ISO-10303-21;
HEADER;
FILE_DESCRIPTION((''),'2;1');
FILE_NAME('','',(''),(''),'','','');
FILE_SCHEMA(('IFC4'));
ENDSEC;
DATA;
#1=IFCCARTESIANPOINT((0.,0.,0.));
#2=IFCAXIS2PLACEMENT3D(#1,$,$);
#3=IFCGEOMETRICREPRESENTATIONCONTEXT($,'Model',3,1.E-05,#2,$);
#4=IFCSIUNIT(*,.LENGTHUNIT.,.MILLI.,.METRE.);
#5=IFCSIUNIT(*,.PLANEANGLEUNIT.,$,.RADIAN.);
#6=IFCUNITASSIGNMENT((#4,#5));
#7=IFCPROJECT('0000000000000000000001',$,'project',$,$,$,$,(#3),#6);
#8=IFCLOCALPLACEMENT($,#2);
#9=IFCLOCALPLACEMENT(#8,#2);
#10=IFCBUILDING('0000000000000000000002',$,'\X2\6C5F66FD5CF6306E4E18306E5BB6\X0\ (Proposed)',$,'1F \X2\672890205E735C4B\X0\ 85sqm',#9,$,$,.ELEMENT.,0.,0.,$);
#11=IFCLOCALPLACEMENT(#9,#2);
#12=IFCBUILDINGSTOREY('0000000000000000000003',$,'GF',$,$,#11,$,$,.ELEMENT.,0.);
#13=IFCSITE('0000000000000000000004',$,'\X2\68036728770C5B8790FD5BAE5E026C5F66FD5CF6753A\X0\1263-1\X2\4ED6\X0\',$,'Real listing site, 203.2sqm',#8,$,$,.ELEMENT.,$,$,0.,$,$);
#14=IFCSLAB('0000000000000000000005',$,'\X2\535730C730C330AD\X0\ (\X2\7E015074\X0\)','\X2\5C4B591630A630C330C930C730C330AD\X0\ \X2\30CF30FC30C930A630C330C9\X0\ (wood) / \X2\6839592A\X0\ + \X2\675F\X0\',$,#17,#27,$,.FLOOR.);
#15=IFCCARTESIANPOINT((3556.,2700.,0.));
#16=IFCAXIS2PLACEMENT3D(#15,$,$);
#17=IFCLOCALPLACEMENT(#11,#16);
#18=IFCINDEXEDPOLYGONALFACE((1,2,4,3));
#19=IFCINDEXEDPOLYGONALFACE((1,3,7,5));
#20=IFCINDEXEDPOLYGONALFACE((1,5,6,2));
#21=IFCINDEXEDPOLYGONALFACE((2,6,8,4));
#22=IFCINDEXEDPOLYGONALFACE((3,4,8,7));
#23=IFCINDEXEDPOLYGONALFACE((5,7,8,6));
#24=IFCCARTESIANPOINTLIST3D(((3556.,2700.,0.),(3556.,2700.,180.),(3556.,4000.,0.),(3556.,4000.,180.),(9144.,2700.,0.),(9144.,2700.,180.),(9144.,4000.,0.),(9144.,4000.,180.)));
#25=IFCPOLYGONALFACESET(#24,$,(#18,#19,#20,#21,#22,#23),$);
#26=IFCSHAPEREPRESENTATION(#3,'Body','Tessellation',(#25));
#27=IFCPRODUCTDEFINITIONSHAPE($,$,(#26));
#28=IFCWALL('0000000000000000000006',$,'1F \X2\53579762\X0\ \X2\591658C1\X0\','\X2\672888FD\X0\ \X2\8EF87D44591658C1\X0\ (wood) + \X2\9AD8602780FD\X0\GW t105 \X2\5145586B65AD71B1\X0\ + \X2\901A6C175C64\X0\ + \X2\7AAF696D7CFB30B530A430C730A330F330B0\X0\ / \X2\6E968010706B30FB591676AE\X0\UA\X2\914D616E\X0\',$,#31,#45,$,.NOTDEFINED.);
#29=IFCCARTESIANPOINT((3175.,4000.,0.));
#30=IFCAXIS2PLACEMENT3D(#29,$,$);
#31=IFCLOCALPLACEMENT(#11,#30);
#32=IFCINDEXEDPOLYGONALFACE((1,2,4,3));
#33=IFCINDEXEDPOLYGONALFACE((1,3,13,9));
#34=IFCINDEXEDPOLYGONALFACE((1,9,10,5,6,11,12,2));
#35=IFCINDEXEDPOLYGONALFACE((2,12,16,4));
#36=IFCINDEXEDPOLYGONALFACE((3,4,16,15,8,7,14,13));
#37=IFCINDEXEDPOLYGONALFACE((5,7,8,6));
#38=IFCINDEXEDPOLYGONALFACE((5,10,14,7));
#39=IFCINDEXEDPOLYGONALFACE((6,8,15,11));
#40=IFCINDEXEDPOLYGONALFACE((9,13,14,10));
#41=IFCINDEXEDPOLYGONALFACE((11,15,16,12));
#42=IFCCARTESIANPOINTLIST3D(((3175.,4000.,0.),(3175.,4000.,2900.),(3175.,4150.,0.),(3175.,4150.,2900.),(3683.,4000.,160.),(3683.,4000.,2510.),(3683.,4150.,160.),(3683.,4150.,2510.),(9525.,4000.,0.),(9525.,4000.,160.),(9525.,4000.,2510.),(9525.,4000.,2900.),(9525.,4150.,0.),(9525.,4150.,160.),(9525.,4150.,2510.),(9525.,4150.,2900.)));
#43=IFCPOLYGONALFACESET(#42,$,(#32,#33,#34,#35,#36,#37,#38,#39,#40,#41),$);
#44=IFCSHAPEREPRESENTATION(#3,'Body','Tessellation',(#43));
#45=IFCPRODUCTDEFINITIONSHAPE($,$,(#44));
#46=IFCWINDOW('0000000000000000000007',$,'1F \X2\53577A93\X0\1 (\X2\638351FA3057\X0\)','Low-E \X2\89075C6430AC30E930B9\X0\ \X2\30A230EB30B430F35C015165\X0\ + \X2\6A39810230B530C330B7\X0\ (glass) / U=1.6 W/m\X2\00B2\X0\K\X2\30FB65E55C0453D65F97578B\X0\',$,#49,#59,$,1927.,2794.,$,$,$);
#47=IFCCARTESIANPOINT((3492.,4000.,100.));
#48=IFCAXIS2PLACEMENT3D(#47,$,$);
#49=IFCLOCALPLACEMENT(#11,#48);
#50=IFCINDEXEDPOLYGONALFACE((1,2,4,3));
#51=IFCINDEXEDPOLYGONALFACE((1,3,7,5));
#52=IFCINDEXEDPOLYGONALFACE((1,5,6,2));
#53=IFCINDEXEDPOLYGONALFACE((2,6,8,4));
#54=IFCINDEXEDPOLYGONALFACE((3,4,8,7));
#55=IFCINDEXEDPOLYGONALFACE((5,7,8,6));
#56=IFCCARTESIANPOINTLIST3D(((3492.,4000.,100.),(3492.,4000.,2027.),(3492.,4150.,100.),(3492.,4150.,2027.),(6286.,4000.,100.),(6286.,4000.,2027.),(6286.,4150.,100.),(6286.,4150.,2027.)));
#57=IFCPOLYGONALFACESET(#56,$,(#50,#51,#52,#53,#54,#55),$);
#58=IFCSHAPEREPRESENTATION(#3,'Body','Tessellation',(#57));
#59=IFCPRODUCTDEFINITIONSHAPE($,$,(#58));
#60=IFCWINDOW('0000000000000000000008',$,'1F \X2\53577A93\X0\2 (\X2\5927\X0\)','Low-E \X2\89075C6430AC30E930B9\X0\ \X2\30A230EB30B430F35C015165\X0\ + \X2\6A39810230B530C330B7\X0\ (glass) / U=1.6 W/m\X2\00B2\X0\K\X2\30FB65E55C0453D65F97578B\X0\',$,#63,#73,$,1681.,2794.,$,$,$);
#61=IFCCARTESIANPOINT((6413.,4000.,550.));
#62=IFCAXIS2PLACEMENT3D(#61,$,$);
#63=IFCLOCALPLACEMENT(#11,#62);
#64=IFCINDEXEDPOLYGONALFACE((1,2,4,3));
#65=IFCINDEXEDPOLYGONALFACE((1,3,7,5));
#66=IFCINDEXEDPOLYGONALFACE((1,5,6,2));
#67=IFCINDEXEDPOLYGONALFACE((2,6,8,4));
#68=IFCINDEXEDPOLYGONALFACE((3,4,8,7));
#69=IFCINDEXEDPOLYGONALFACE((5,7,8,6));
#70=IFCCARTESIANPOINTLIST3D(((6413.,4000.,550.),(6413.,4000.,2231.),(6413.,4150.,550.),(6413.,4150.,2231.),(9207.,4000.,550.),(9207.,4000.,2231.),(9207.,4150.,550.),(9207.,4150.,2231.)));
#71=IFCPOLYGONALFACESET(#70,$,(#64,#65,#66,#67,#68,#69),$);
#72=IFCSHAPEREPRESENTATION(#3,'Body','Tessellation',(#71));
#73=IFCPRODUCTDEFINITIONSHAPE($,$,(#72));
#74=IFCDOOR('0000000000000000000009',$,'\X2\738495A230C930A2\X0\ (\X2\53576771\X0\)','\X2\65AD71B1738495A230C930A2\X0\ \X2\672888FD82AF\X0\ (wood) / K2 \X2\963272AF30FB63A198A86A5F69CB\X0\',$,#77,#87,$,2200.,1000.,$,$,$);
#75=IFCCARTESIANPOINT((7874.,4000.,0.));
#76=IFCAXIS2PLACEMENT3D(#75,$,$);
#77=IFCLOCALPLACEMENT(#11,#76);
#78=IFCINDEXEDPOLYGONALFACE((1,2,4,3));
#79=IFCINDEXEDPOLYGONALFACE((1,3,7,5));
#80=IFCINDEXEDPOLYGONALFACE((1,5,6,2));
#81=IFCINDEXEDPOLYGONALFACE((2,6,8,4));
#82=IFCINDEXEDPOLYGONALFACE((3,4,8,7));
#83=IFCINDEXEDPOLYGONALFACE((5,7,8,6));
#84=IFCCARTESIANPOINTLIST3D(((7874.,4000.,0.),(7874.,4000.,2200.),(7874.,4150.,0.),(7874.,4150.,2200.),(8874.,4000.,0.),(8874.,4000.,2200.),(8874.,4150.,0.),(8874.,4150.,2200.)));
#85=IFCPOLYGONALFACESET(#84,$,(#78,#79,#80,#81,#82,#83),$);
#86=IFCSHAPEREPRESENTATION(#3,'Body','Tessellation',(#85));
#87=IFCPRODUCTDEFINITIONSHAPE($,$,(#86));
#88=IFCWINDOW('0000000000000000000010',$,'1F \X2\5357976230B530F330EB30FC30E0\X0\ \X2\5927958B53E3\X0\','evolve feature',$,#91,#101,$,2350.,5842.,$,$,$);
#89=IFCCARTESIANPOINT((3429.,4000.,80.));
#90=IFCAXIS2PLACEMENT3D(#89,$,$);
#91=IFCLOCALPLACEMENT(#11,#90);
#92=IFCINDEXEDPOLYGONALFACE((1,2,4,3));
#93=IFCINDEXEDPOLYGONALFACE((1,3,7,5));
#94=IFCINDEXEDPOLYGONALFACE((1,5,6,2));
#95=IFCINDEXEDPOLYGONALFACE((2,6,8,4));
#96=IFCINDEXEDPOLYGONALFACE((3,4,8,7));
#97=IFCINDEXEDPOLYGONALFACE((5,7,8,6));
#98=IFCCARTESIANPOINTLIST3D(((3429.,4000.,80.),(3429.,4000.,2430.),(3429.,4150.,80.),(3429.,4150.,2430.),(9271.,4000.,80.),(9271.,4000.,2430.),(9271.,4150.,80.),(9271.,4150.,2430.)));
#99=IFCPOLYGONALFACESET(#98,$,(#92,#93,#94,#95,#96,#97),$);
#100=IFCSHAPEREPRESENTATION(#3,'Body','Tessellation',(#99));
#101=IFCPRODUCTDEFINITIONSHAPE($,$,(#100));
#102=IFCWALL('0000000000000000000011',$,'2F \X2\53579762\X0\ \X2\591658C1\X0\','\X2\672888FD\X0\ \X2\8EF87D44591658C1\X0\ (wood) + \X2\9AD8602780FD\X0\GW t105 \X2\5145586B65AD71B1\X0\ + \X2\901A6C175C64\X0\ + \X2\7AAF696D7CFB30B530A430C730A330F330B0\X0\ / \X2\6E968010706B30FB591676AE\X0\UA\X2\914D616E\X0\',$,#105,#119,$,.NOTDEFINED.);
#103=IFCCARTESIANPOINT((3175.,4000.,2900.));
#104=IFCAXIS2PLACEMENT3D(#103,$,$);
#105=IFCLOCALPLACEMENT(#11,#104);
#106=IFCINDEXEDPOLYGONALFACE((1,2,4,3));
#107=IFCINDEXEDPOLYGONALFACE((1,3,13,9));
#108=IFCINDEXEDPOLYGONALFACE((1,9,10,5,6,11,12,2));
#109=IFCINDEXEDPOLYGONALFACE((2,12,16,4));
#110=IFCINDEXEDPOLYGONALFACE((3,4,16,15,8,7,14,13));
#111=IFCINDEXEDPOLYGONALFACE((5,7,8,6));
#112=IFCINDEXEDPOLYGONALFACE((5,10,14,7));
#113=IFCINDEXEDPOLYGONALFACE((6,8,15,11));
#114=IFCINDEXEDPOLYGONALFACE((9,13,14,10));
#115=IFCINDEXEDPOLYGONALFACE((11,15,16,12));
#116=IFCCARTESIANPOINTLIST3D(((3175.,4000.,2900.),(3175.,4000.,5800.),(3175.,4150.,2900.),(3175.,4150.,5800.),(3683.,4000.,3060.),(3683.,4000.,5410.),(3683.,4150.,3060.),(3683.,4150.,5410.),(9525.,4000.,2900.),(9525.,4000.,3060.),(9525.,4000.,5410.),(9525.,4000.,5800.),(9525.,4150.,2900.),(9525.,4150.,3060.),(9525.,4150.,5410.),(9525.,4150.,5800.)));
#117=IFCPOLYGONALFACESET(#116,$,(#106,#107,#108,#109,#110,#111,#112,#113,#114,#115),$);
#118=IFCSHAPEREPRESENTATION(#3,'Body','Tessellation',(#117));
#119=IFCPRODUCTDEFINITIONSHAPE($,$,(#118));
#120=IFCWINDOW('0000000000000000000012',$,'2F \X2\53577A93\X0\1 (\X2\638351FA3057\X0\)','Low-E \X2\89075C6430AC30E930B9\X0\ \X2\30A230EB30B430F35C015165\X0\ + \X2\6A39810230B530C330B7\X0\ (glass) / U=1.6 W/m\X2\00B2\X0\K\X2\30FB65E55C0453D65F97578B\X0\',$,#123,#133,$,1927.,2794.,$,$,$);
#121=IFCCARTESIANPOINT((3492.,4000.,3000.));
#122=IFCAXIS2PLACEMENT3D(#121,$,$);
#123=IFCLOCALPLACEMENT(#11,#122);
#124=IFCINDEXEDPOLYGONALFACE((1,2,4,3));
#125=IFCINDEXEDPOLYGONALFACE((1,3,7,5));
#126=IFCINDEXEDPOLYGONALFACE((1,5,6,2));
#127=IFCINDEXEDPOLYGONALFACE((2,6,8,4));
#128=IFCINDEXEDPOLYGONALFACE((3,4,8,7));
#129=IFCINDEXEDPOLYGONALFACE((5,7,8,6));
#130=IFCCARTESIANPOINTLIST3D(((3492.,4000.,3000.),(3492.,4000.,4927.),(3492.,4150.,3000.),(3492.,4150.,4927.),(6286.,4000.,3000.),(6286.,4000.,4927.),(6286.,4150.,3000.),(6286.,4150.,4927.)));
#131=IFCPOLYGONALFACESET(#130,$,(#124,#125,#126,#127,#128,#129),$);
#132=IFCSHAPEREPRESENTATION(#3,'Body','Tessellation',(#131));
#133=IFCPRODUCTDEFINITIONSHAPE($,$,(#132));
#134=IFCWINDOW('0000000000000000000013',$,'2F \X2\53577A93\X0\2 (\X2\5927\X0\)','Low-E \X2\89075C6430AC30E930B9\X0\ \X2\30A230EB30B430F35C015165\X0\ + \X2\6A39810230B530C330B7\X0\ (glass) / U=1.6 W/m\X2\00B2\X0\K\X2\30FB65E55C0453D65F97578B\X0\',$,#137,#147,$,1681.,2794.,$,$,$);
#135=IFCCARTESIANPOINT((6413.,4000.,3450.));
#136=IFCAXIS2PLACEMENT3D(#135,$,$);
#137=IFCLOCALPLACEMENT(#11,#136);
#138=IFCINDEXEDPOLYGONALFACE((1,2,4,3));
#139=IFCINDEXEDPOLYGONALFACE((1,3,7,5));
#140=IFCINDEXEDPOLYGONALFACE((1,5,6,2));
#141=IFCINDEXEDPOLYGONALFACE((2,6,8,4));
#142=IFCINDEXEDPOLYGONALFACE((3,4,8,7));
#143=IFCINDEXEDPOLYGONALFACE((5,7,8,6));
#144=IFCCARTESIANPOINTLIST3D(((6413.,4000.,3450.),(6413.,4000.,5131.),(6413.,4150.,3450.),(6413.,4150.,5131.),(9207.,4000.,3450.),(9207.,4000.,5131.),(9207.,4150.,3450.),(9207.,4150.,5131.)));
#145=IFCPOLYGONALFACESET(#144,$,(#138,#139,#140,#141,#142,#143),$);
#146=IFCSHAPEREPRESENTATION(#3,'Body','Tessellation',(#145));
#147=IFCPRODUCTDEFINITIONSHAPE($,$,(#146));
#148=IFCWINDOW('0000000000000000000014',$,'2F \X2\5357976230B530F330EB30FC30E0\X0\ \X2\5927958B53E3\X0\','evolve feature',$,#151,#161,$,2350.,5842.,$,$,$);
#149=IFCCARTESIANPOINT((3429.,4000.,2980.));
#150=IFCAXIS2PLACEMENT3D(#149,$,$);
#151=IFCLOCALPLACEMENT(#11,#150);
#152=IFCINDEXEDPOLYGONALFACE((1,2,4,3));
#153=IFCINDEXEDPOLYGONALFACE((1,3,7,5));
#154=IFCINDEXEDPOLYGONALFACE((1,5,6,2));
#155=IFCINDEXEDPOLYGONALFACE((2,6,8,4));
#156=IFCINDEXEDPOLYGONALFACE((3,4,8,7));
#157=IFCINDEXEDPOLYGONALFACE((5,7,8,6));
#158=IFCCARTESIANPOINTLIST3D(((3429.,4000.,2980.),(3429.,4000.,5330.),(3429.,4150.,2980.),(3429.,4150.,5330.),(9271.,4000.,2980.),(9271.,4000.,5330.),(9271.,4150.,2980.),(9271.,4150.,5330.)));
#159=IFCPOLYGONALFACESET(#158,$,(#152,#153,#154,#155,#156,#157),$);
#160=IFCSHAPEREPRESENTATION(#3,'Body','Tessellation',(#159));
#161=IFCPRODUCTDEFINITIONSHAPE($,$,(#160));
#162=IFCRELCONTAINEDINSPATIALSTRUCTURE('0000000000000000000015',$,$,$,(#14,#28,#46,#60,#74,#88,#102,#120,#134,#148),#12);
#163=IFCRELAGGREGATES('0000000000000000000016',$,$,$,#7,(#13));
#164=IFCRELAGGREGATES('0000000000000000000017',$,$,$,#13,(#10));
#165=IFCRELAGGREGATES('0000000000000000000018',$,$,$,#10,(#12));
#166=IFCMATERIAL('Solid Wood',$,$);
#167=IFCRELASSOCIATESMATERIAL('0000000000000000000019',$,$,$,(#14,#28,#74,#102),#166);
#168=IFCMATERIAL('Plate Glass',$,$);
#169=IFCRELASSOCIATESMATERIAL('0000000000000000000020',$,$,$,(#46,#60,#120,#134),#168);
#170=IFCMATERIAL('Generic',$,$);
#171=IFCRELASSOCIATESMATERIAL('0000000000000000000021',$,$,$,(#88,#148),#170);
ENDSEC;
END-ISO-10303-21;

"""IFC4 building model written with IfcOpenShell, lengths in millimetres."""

from ifc_helpers import new_model, si_unit, frame, frame_2d, origin, place, context, project, spatial, rectangle, extrude, material, element, fill, save


model = new_model("IFC4")

# Units and contexts
model_context = context("Model", 3, precision=1e-05, world=origin())
ifc_project = project(units=[si_unit("LENGTHUNIT", "METRE", prefix="MILLI"), si_unit("PLANEANGLEUNIT", "RADIAN")], contexts=[model_context])

# Site, building, storey
site_placement = place(None, origin())
site = spatial("IfcSite", under=ifc_project, at=site_placement, Name="栃木県宇都宮市江曽島町1263-1他", ObjectType="Real listing site, 203.2sqm", CompositionType="ELEMENT", RefElevation=0.0)
building_placement = place(site_placement, origin())
building = spatial("IfcBuilding", under=site, at=building_placement, Name="江曽島の丘の家 (Proposed)", ObjectType="1F 木造平屋 85sqm", CompositionType="ELEMENT", ElevationOfRefHeight=0.0, ElevationOfTerrain=0.0)
storey_placement = place(building_placement, origin())
storey = spatial("IfcBuildingStorey", under=building, at=storey_placement, Name="GF", CompositionType="ELEMENT", Elevation=0.0)

# Slab
ifc_material_1 = material(Name="Solid Wood")
slab_1_placement = place(storey_placement, frame((3556.0, 2700.0, 0.0)))
element("IfcSlab", 1, at=slab_1_placement, inside=storey, material=ifc_material_1, Name="南デッキ (縁側)", Description="屋外ウッドデッキ ハードウッド (wood) / 根太 + 束", PredefinedType="FLOOR", context=model_context, shape_type="SweptSolid", body=[
    extrude(rectangle(XDim=5588.0, YDim=1300.0, at=frame_2d((2794.0, 650.0))), frame((3556.0, 2700.0, 0.0)), (0.0, 0.0, 1.0), 180.0),
])
ifc_material_2 = material(Name="Generic")

# Wall, openings, windows, door
wall_1_placement = place(storey_placement, frame((3175.0, 4000.0, 0.0)))
wall_1 = element("IfcWall", 2, at=wall_1_placement, inside=storey, material=ifc_material_1, Name="1F 南面 外壁", Description="木製 軸組外壁 (wood) + 高性能GW t105 充填断熱 + 通気層 + 窯業系サイディング / 準耐火・外皮UA配慮", PredefinedType="NOTDEFINED", context=model_context, shape_type="SweptSolid", body=[
    extrude(rectangle(XDim=6350.0, YDim=150.0, at=frame_2d((3175.0, 75.0))), frame((3175.0, 4000.0, 0.0)), (0.0, 0.0, 1.0), 2900.0),
])
opening_1_placement = place(storey_placement, frame((3492.0, 4000.0, 100.0)))
opening_1 = element("IfcOpeningElement", 3, at=opening_1_placement, cuts=wall_1, PredefinedType="NOTDEFINED", context=model_context, shape_type="SweptSolid", body=[
    extrude(rectangle(XDim=2794.0, YDim=150.0, at=frame_2d((1397.0, 75.0))), frame((3492.0, 4000.0, 100.0)), (0.0, 0.0, 1.0), 1927.0),
])
opening_2_placement = place(storey_placement, frame((6413.0, 4000.0, 550.0)))
opening_2 = element("IfcOpeningElement", 4, at=opening_2_placement, cuts=wall_1, PredefinedType="NOTDEFINED", context=model_context, shape_type="SweptSolid", body=[
    extrude(rectangle(XDim=2794.0, YDim=150.0, at=frame_2d((1397.0, 75.0))), frame((6413.0, 4000.0, 550.0)), (0.0, 0.0, 1.0), 1681.0),
])
opening_3_placement = place(storey_placement, frame((7874.0, 4000.0, 0.0)))
opening_3 = element("IfcOpeningElement", 5, at=opening_3_placement, cuts=wall_1, PredefinedType="NOTDEFINED", context=model_context, shape_type="SweptSolid", body=[
    extrude(rectangle(XDim=1000.0, YDim=150.0, at=frame_2d((500.0, 75.0))), frame((7874.0, 4000.0, 0.0)), (0.0, 0.0, 1.0), 2200.0),
])
opening_4_placement = place(storey_placement, frame((3429.0, 4000.0, 80.0)))
opening_4 = element("IfcOpeningElement", 6, at=opening_4_placement, cuts=wall_1, PredefinedType="NOTDEFINED", context=model_context, shape_type="SweptSolid", body=[
    extrude(rectangle(XDim=5842.0, YDim=150.0, at=frame_2d((2921.0, 75.0))), frame((3429.0, 4000.0, 80.0)), (0.0, 0.0, 1.0), 2350.0),
])
ifc_material_3 = material(Name="Plate Glass")
window_1_placement = place(storey_placement, frame((3492.0, 4000.0, 100.0)))
window_1 = element("IfcWindow", 7, at=window_1_placement, inside=storey, material=ifc_material_3, Name="1F 南窓1 (掃出し)", Description="Low-E 複層ガラス アルゴン封入 + 樹脂サッシ (glass) / U=1.6 W/m²K・日射取得型", OverallHeight=1927.0, OverallWidth=2794.0, context=model_context, shape_type="SweptSolid", body=[
    extrude(rectangle(XDim=2794.0, YDim=150.0, at=frame_2d((1397.0, 75.0))), frame((3492.0, 4000.0, 100.0)), (0.0, 0.0, 1.0), 1927.0),
])
fill(opening_1, window_1)
window_2_placement = place(storey_placement, frame((6413.0, 4000.0, 550.0)))
window_2 = element("IfcWindow", 8, at=window_2_placement, inside=storey, material=ifc_material_3, Name="1F 南窓2 (大)", Description="Low-E 複層ガラス アルゴン封入 + 樹脂サッシ (glass) / U=1.6 W/m²K・日射取得型", OverallHeight=1681.0, OverallWidth=2794.0, context=model_context, shape_type="SweptSolid", body=[
    extrude(rectangle(XDim=2794.0, YDim=150.0, at=frame_2d((1397.0, 75.0))), frame((6413.0, 4000.0, 550.0)), (0.0, 0.0, 1.0), 1681.0),
])
fill(opening_2, window_2)
door_placement = place(storey_placement, frame((7874.0, 4000.0, 0.0)))
door = element("IfcDoor", 9, at=door_placement, inside=storey, material=ifc_material_1, Name="玄関ドア (南東)", Description="断熱玄関ドア 木製芯 (wood) / K2 防犯・採風機構", OverallHeight=2200.0, OverallWidth=1000.0, context=model_context, shape_type="SweptSolid", body=[
    extrude(rectangle(XDim=1000.0, YDim=150.0, at=frame_2d((500.0, 75.0))), frame((7874.0, 4000.0, 0.0)), (0.0, 0.0, 1.0), 2200.0),
])
fill(opening_3, door)
window_3_placement = place(storey_placement, frame((3429.0, 4000.0, 80.0)))
window_3 = element("IfcWindow", 10, at=window_3_placement, inside=storey, material=ifc_material_2, Name="1F 南面サンルーム 大開口", Description="evolve feature", OverallHeight=2350.0, OverallWidth=5842.0, context=model_context, shape_type="SweptSolid", body=[
    extrude(rectangle(XDim=5842.0, YDim=150.0, at=frame_2d((2921.0, 75.0))), frame((3429.0, 4000.0, 80.0)), (0.0, 0.0, 1.0), 2350.0),
])
fill(opening_4, window_3)

# Wall, openings, windows
wall_2_placement = place(storey_placement, frame((3175.0, 4000.0, 2900.0)))
wall_2 = element("IfcWall", 11, at=wall_2_placement, inside=storey, material=ifc_material_1, Name="2F 南面 外壁", Description="木製 軸組外壁 (wood) + 高性能GW t105 充填断熱 + 通気層 + 窯業系サイディング / 準耐火・外皮UA配慮", PredefinedType="NOTDEFINED", context=model_context, shape_type="SweptSolid", body=[
    extrude(rectangle(XDim=6350.0, YDim=150.0, at=frame_2d((3175.0, 75.0))), frame((3175.0, 4000.0, 2900.0)), (0.0, 0.0, 1.0), 2900.0),
])
opening_5_placement = place(storey_placement, frame((3492.0, 4000.0, 3000.0)))
opening_5 = element("IfcOpeningElement", 12, at=opening_5_placement, cuts=wall_2, PredefinedType="NOTDEFINED", context=model_context, shape_type="SweptSolid", body=[
    extrude(rectangle(XDim=2794.0, YDim=150.0, at=frame_2d((1397.0, 75.0))), frame((3492.0, 4000.0, 3000.0)), (0.0, 0.0, 1.0), 1927.0),
])
opening_6_placement = place(storey_placement, frame((6413.0, 4000.0, 3450.0)))
opening_6 = element("IfcOpeningElement", 13, at=opening_6_placement, cuts=wall_2, PredefinedType="NOTDEFINED", context=model_context, shape_type="SweptSolid", body=[
    extrude(rectangle(XDim=2794.0, YDim=150.0, at=frame_2d((1397.0, 75.0))), frame((6413.0, 4000.0, 3450.0)), (0.0, 0.0, 1.0), 1681.0),
])
opening_7_placement = place(storey_placement, frame((3429.0, 4000.0, 2980.0)))
opening_7 = element("IfcOpeningElement", 14, at=opening_7_placement, cuts=wall_2, PredefinedType="NOTDEFINED", context=model_context, shape_type="SweptSolid", body=[
    extrude(rectangle(XDim=5842.0, YDim=150.0, at=frame_2d((2921.0, 75.0))), frame((3429.0, 4000.0, 2980.0)), (0.0, 0.0, 1.0), 2350.0),
])
window_4_placement = place(storey_placement, frame((3492.0, 4000.0, 3000.0)))
window_4 = element("IfcWindow", 15, at=window_4_placement, inside=storey, material=ifc_material_3, Name="2F 南窓1 (掃出し)", Description="Low-E 複層ガラス アルゴン封入 + 樹脂サッシ (glass) / U=1.6 W/m²K・日射取得型", OverallHeight=1927.0, OverallWidth=2794.0, context=model_context, shape_type="SweptSolid", body=[
    extrude(rectangle(XDim=2794.0, YDim=150.0, at=frame_2d((1397.0, 75.0))), frame((3492.0, 4000.0, 3000.0)), (0.0, 0.0, 1.0), 1927.0),
])
fill(opening_5, window_4)
window_5_placement = place(storey_placement, frame((6413.0, 4000.0, 3450.0)))
window_5 = element("IfcWindow", 16, at=window_5_placement, inside=storey, material=ifc_material_3, Name="2F 南窓2 (大)", Description="Low-E 複層ガラス アルゴン封入 + 樹脂サッシ (glass) / U=1.6 W/m²K・日射取得型", OverallHeight=1681.0, OverallWidth=2794.0, context=model_context, shape_type="SweptSolid", body=[
    extrude(rectangle(XDim=2794.0, YDim=150.0, at=frame_2d((1397.0, 75.0))), frame((6413.0, 4000.0, 3450.0)), (0.0, 0.0, 1.0), 1681.0),
])
fill(opening_6, window_5)
window_6_placement = place(storey_placement, frame((3429.0, 4000.0, 2980.0)))
window_6 = element("IfcWindow", 17, at=window_6_placement, inside=storey, material=ifc_material_2, Name="2F 南面サンルーム 大開口", Description="evolve feature", OverallHeight=2350.0, OverallWidth=5842.0, context=model_context, shape_type="SweptSolid", body=[
    extrude(rectangle(XDim=5842.0, YDim=150.0, at=frame_2d((2921.0, 75.0))), frame((3429.0, 4000.0, 2980.0)), (0.0, 0.0, 1.0), 2350.0),
])
fill(opening_7, window_6)

save(model, "model.ifc")
